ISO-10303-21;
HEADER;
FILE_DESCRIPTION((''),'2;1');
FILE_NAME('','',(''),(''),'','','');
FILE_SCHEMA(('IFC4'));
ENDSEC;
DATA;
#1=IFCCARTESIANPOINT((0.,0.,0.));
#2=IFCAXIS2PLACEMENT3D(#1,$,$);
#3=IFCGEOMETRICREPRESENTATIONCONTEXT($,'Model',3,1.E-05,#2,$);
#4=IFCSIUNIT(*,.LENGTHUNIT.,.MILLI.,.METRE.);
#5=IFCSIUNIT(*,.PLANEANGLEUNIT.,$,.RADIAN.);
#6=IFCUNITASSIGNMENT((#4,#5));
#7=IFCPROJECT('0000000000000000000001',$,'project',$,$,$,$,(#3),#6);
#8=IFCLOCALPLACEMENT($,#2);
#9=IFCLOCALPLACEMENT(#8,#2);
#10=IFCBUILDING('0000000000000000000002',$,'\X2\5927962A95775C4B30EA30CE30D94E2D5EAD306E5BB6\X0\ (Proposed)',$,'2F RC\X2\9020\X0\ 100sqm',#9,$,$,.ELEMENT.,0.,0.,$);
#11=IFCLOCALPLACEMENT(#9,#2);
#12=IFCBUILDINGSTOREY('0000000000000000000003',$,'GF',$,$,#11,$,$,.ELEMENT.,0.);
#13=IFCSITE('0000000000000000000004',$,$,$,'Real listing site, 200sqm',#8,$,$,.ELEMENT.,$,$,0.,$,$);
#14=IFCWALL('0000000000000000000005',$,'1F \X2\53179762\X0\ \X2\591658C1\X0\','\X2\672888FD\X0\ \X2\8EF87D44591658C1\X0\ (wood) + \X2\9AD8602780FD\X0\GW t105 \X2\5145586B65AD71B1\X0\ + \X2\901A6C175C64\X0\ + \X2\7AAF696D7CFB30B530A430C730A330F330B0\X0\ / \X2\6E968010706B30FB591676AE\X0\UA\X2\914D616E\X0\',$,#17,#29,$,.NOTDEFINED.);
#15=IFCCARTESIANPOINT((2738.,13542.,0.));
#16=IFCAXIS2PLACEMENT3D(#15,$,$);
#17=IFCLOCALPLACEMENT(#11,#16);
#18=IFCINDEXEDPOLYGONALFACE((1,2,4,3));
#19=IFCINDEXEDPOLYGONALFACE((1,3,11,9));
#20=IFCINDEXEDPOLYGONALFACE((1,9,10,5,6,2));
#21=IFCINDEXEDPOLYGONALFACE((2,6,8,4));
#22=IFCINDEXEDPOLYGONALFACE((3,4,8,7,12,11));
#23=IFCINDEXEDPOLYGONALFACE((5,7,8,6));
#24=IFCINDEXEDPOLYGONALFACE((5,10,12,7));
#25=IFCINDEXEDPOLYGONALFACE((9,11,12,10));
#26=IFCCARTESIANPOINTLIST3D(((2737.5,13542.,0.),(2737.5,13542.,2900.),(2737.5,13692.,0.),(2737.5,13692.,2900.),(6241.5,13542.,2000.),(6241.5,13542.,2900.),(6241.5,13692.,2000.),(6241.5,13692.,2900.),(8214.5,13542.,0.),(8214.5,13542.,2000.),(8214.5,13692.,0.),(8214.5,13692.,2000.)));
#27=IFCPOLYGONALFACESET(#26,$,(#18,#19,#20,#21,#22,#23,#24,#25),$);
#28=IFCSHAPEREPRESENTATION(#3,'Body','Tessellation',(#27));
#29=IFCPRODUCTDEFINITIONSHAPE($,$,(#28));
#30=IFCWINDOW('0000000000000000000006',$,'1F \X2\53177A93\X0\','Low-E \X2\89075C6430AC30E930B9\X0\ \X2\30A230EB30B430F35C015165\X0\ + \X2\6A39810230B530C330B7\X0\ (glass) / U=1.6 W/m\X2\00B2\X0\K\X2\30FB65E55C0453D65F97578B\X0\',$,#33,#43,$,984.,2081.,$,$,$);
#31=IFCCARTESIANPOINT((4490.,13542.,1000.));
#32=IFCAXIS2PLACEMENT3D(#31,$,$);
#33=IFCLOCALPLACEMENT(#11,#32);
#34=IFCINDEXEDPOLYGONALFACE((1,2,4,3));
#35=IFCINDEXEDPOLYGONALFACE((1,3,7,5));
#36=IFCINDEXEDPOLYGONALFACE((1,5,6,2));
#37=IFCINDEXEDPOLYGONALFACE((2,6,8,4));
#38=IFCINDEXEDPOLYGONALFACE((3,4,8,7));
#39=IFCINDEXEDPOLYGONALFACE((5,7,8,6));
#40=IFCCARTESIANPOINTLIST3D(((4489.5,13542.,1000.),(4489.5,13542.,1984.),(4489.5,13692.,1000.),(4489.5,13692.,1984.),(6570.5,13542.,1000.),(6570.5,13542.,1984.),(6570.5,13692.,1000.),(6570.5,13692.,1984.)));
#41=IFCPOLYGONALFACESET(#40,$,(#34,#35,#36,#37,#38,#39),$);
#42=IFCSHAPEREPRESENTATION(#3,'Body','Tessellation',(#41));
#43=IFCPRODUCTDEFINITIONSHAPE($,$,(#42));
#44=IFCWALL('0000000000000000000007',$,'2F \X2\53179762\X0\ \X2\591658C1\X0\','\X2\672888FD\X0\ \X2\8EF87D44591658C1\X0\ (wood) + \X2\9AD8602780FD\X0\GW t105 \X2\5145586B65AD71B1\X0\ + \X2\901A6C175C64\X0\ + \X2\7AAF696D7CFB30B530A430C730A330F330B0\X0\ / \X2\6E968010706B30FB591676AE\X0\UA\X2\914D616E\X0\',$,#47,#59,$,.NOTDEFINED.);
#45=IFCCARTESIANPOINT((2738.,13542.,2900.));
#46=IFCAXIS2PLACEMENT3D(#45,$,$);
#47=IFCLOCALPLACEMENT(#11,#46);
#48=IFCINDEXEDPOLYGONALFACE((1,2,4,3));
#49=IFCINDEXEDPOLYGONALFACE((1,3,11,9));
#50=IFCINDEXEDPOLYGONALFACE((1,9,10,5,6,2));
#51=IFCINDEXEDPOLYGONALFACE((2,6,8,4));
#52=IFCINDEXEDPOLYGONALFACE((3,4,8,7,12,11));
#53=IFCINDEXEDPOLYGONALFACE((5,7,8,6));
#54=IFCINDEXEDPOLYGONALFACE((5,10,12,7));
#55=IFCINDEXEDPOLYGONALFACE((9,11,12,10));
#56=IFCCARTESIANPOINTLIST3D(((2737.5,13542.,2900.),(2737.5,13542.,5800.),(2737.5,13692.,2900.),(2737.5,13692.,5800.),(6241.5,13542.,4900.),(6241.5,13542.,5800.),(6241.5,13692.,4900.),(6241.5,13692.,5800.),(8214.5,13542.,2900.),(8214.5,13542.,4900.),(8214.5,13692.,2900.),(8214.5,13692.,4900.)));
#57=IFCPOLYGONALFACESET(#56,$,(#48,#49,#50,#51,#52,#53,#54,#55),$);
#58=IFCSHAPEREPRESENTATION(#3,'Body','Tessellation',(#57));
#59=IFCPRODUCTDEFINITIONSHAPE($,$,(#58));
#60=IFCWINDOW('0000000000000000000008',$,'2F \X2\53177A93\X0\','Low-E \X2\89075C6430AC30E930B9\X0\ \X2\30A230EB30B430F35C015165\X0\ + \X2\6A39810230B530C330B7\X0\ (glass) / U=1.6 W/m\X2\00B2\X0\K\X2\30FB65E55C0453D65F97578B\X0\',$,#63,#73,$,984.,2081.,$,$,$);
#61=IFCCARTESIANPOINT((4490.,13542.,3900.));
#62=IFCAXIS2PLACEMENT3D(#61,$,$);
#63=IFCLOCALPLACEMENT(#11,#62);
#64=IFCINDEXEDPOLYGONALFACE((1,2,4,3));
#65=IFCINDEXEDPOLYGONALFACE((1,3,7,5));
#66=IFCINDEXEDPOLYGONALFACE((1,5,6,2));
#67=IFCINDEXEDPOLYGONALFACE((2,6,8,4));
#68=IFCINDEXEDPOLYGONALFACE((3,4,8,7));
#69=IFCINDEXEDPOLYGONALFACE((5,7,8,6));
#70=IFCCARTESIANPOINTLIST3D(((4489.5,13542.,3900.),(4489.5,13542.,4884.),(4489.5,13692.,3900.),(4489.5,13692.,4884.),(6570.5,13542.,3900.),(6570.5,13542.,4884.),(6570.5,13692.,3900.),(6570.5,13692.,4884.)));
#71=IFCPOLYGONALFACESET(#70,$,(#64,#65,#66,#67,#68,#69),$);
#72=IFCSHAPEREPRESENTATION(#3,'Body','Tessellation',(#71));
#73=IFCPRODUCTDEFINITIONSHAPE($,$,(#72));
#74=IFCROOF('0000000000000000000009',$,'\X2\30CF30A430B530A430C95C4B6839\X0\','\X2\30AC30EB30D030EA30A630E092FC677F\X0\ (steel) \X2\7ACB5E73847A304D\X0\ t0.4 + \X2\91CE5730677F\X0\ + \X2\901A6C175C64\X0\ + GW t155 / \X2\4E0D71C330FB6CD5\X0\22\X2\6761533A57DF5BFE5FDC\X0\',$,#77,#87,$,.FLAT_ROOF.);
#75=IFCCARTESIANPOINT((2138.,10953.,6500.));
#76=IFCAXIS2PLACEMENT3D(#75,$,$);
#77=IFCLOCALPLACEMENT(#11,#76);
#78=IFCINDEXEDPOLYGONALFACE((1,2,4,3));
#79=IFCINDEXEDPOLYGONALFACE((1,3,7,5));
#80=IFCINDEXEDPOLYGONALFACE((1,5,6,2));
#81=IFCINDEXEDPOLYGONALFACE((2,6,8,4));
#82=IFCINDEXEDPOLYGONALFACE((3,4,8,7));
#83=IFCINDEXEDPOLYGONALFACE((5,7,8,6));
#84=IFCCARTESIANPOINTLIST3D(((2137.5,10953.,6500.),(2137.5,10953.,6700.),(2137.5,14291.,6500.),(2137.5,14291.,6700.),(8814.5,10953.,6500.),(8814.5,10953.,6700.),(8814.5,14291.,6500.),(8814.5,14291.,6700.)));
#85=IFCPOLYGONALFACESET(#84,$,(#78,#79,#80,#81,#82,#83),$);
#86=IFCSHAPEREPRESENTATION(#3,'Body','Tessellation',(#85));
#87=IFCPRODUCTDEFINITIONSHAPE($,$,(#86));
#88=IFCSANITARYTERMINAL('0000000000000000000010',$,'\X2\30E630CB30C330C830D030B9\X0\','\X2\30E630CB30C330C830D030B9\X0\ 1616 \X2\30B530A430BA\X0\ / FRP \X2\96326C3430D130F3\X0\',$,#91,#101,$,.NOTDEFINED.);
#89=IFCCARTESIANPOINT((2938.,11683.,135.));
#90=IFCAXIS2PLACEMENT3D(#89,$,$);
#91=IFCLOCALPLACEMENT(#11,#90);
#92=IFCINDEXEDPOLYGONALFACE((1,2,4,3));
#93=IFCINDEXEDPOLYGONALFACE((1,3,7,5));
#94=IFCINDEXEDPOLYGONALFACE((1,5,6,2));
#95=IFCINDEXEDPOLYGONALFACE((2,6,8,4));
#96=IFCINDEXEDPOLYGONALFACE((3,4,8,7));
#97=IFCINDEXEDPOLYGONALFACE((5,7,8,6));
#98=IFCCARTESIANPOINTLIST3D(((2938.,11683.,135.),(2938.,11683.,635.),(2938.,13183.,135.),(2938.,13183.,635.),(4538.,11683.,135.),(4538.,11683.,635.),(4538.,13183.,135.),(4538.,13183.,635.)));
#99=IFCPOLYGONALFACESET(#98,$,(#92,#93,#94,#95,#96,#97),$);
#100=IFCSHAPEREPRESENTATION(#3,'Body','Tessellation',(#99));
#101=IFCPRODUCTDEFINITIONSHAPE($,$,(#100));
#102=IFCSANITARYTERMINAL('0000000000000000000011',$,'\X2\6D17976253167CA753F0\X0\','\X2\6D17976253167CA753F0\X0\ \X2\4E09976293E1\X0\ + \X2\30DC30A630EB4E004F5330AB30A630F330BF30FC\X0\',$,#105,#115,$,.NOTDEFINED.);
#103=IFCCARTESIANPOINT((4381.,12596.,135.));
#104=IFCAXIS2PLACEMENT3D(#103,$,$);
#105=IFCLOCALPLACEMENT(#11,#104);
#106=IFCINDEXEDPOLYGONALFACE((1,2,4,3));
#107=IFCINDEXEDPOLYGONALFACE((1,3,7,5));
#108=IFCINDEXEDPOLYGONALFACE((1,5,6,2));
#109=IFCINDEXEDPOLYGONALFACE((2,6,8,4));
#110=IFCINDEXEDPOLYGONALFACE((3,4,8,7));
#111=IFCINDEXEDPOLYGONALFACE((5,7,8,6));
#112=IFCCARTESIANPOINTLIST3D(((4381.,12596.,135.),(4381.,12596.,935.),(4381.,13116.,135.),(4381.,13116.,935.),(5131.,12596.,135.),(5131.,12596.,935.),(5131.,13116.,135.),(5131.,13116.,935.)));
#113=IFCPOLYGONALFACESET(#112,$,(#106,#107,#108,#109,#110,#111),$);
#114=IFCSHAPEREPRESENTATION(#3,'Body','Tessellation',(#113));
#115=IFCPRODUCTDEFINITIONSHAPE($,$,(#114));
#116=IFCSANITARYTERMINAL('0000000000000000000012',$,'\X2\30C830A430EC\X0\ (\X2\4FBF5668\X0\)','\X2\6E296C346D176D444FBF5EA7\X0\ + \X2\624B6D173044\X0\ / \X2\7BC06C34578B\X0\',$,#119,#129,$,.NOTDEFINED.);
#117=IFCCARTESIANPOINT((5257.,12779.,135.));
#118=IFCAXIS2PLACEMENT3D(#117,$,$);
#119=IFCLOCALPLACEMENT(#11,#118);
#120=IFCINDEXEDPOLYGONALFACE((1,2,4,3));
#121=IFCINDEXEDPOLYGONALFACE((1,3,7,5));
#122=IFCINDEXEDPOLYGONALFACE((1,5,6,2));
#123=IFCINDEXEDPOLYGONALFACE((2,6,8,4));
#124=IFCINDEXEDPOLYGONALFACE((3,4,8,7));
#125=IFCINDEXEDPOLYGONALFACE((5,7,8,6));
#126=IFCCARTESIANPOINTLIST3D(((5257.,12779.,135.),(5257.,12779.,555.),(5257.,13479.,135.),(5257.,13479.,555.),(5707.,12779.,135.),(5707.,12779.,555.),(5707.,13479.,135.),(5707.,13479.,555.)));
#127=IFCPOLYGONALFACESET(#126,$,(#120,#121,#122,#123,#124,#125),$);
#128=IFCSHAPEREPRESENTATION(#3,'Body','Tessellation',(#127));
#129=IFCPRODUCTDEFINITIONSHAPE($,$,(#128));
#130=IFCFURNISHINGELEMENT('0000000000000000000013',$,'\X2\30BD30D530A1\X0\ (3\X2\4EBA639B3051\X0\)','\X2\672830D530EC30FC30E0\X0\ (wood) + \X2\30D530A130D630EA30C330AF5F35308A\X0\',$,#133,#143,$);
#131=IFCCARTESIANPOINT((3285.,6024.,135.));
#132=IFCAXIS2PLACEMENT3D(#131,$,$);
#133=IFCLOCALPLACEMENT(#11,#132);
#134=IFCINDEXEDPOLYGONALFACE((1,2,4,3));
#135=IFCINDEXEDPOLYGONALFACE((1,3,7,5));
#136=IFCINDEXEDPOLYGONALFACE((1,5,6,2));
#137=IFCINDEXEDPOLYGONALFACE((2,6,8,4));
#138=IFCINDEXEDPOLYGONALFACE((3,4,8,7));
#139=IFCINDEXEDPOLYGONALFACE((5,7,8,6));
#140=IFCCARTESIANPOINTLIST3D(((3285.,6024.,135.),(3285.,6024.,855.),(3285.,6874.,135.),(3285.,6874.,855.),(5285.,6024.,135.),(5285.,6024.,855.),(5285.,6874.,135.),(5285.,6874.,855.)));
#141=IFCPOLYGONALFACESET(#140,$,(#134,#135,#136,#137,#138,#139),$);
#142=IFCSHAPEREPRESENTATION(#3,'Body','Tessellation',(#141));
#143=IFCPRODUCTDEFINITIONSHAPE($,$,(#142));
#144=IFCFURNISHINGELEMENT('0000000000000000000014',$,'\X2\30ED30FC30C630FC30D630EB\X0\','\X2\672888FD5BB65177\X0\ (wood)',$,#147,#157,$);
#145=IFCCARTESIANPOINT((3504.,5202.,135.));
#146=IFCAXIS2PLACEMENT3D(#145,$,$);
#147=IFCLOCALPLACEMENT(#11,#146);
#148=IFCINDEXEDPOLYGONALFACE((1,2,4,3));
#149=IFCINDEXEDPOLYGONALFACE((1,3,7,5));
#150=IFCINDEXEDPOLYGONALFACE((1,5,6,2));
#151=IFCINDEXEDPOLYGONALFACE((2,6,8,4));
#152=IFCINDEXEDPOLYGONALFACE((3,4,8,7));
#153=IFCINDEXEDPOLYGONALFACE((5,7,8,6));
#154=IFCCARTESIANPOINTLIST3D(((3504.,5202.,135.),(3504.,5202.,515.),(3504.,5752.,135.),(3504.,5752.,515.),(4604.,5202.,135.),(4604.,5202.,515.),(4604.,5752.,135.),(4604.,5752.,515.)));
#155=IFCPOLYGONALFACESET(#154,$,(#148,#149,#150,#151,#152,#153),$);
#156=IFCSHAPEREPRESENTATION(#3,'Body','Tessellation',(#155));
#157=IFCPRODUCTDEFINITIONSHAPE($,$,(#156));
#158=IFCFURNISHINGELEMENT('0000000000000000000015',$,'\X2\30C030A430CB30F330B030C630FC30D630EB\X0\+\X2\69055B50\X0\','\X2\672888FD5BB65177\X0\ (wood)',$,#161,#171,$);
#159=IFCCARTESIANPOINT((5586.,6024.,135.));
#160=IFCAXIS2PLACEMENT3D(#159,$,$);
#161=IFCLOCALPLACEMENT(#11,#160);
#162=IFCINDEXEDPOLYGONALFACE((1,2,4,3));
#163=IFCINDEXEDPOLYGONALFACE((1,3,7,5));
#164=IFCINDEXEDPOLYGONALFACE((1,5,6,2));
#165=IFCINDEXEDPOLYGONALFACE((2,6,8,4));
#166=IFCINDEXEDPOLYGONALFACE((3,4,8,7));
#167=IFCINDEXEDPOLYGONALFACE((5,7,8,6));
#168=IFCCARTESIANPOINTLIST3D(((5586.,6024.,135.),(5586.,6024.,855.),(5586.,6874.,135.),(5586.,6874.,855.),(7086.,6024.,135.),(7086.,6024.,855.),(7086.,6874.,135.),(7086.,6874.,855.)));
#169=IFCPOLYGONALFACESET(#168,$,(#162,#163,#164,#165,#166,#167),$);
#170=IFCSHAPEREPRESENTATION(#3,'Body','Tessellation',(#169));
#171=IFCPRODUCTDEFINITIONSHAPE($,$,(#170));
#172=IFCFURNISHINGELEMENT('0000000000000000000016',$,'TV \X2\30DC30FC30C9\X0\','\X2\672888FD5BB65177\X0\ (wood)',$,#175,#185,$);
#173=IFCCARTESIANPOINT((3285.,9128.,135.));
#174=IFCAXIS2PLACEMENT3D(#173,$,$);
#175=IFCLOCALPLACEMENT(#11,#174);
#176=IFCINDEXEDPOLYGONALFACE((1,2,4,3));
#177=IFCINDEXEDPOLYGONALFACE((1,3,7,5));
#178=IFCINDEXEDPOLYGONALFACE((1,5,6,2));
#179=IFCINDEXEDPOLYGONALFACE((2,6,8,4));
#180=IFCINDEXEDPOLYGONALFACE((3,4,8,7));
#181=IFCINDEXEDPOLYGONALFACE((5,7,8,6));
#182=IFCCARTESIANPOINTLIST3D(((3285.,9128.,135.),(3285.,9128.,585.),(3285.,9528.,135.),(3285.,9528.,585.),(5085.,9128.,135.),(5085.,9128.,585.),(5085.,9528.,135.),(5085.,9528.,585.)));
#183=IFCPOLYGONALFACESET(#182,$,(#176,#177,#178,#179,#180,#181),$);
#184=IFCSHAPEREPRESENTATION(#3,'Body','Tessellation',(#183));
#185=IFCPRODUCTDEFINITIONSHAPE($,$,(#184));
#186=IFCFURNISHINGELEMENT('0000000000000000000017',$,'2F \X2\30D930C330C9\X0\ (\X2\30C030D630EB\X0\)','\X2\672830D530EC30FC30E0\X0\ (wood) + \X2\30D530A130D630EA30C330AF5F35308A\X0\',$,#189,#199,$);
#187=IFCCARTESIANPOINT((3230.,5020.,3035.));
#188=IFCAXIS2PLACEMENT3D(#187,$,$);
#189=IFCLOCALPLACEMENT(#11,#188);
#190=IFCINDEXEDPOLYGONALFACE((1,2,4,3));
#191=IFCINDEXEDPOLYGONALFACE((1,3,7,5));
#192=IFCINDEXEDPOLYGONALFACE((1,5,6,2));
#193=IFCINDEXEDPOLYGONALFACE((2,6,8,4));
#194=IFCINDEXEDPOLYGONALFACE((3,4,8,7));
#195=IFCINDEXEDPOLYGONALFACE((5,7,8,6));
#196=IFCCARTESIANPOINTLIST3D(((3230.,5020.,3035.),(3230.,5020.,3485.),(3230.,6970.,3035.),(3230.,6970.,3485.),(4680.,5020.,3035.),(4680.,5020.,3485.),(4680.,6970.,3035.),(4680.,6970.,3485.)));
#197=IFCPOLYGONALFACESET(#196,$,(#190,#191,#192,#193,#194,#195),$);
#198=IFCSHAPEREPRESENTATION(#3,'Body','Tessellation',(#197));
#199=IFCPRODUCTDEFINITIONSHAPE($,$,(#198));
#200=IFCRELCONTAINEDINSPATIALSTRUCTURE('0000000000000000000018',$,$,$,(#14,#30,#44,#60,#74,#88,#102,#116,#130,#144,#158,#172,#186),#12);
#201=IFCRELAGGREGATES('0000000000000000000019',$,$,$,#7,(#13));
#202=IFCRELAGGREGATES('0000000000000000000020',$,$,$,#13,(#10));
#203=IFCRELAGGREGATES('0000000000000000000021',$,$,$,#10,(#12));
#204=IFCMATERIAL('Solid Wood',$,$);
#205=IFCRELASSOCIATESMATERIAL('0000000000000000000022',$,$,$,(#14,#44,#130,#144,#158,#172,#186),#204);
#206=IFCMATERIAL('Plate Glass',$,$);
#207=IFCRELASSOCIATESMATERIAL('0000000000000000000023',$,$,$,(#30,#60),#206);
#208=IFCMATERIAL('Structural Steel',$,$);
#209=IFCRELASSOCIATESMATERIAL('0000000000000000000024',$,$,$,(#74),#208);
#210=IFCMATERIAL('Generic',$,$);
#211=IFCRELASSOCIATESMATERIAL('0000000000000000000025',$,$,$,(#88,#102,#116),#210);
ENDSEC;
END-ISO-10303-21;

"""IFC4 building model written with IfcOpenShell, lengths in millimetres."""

from ifc_helpers import new_model, si_unit, frame, frame_2d, origin, place, context, project, spatial, rectangle, extrude, material, element, fill, save


model = new_model("IFC4")

# Units and contexts
model_context = context("Model", 3, precision=1e-05, world=origin())
ifc_project = project(units=[si_unit("LENGTHUNIT", "METRE", prefix="MILLI"), si_unit("PLANEANGLEUNIT", "RADIAN")], contexts=[model_context])

# Site, building, storey
site_placement = place(None, origin())
site = spatial("IfcSite", under=ifc_project, at=site_placement, ObjectType="Real listing site, 200sqm", CompositionType="ELEMENT", RefElevation=0.0)
building_placement = place(site_placement, origin())
building = spatial("IfcBuilding", under=site, at=building_placement, Name="大阪長屋リノベ中庭の家 (Proposed)", ObjectType="2F RC造 100sqm", CompositionType="ELEMENT", ElevationOfRefHeight=0.0, ElevationOfTerrain=0.0)
storey_placement = place(building_placement, origin())
storey = spatial("IfcBuildingStorey", under=building, at=storey_placement, Name="GF", CompositionType="ELEMENT", Elevation=0.0)

# Wall, opening, window
ifc_material_1 = material(Name="Solid Wood")
wall_1_placement = place(storey_placement, frame((2738.0, 13542.0, 0.0)))
wall_1 = element("IfcWall", 1, at=wall_1_placement, inside=storey, material=ifc_material_1, Name="1F 北面 外壁", Description="木製 軸組外壁 (wood) + 高性能GW t105 充填断熱 + 通気層 + 窯業系サイディング / 準耐火・外皮UA配慮", PredefinedType="NOTDEFINED", context=model_context, shape_type="SweptSolid", body=[
    extrude(rectangle(XDim=5477.0, YDim=150.0, at=frame_2d((2738.0, 75.0))), frame((2738.0, 13542.0, 0.0)), (0.0, 0.0, 1.0), 2900.0),
])
opening_1_placement = place(storey_placement, frame((4490.0, 13542.0, 1000.0)))
opening_1 = element("IfcOpeningElement", 2, at=opening_1_placement, cuts=wall_1, PredefinedType="NOTDEFINED", context=model_context, shape_type="SweptSolid", body=[
    extrude(rectangle(XDim=2081.0, YDim=150.0, at=frame_2d((1040.0, 75.0))), frame((4490.0, 13542.0, 1000.0)), (0.0, 0.0, 1.0), 984.0),
])
ifc_material_2 = material(Name="Plate Glass")
window_1_placement = place(storey_placement, frame((4490.0, 13542.0, 1000.0)))
window_1 = element("IfcWindow", 3, at=window_1_placement, inside=storey, material=ifc_material_2, Name="1F 北窓", Description="Low-E 複層ガラス アルゴン封入 + 樹脂サッシ (glass) / U=1.6 W/m²K・日射取得型", OverallHeight=984.0, OverallWidth=2081.0, context=model_context, shape_type="SweptSolid", body=[
    extrude(rectangle(XDim=2081.0, YDim=150.0, at=frame_2d((1040.0, 75.0))), frame((4490.0, 13542.0, 1000.0)), (0.0, 0.0, 1.0), 984.0),
])
fill(opening_1, window_1)

# Wall, opening, window
wall_2_placement = place(storey_placement, frame((2738.0, 13542.0, 2900.0)))
wall_2 = element("IfcWall", 4, at=wall_2_placement, inside=storey, material=ifc_material_1, Name="2F 北面 外壁", Description="木製 軸組外壁 (wood) + 高性能GW t105 充填断熱 + 通気層 + 窯業系サイディング / 準耐火・外皮UA配慮", PredefinedType="NOTDEFINED", context=model_context, shape_type="SweptSolid", body=[
    extrude(rectangle(XDim=5477.0, YDim=150.0, at=frame_2d((2738.0, 75.0))), frame((2738.0, 13542.0, 2900.0)), (0.0, 0.0, 1.0), 2900.0),
])
opening_2_placement = place(storey_placement, frame((4490.0, 13542.0, 3900.0)))
opening_2 = element("IfcOpeningElement", 5, at=opening_2_placement, cuts=wall_2, PredefinedType="NOTDEFINED", context=model_context, shape_type="SweptSolid", body=[
    extrude(rectangle(XDim=2081.0, YDim=150.0, at=frame_2d((1040.0, 75.0))), frame((4490.0, 13542.0, 3900.0)), (0.0, 0.0, 1.0), 984.0),
])
window_2_placement = place(storey_placement, frame((4490.0, 13542.0, 3900.0)))
window_2 = element("IfcWindow", 6, at=window_2_placement, inside=storey, material=ifc_material_2, Name="2F 北窓", Description="Low-E 複層ガラス アルゴン封入 + 樹脂サッシ (glass) / U=1.6 W/m²K・日射取得型", OverallHeight=984.0, OverallWidth=2081.0, context=model_context, shape_type="SweptSolid", body=[
    extrude(rectangle(XDim=2081.0, YDim=150.0, at=frame_2d((1040.0, 75.0))), frame((4490.0, 13542.0, 3900.0)), (0.0, 0.0, 1.0), 984.0),
])
fill(opening_2, window_2)

# Roof
ifc_material_3 = material(Name="Structural Steel")
roof_placement = place(storey_placement, frame((2138.0, 10953.0, 6500.0)))
element("IfcRoof", 7, at=roof_placement, inside=storey, material=ifc_material_3, Name="ハイサイド屋根", Description="ガルバリウム鋼板 (steel) 立平葺き t0.4 + 野地板 + 通気層 + GW t155 / 不燃・法22条区域対応", PredefinedType="FLAT_ROOF", context=model_context, shape_type="SweptSolid", body=[
    extrude(rectangle(XDim=6677.0, YDim=3338.0, at=frame_2d((3338.0, 1669.0))), frame((2138.0, 10953.0, 6500.0)), (0.0, 0.0, 1.0), 200.0),
])

# Sanitary terminals
ifc_material_4 = material(Name="Generic")
sanitary_terminal_1_placement = place(storey_placement, frame((2938.0, 11683.0, 135.0)))
element("IfcSanitaryTerminal", 8, at=sanitary_terminal_1_placement, inside=storey, material=ifc_material_4, Name="ユニットバス", Description="ユニットバス 1616 サイズ / FRP 防水パン", PredefinedType="NOTDEFINED", context=model_context, shape_type="SweptSolid", body=[
    extrude(rectangle(XDim=1600.0, YDim=1500.0, at=frame_2d((800.0, 750.0))), frame((2938.0, 11683.0, 135.0)), (0.0, 0.0, 1.0), 500.0),
])
sanitary_terminal_2_placement = place(storey_placement, frame((4381.0, 12596.0, 135.0)))
element("IfcSanitaryTerminal", 9, at=sanitary_terminal_2_placement, inside=storey, material=ifc_material_4, Name="洗面化粧台", Description="洗面化粧台 三面鏡 + ボウル一体カウンター", PredefinedType="NOTDEFINED", context=model_context, shape_type="SweptSolid", body=[
    extrude(rectangle(XDim=750.0, YDim=520.0, at=frame_2d((375.0, 260.0))), frame((4381.0, 12596.0, 135.0)), (0.0, 0.0, 1.0), 800.0),
])
sanitary_terminal_3_placement = place(storey_placement, frame((5257.0, 12779.0, 135.0)))
element("IfcSanitaryTerminal", 10, at=sanitary_terminal_3_placement, inside=storey, material=ifc_material_4, Name="トイレ (便器)", Description="温水洗浄便座 + 手洗い / 節水型", PredefinedType="NOTDEFINED", context=model_context, shape_type="SweptSolid", body=[
    extrude(rectangle(XDim=450.0, YDim=700.0, at=frame_2d((225.0, 350.0))), frame((5257.0, 12779.0, 135.0)), (0.0, 0.0, 1.0), 420.0),
])

# Furnishing elements
furnishing_1_placement = place(storey_placement, frame((3285.0, 6024.0, 135.0)))
element("IfcFurnishingElement", 11, at=furnishing_1_placement, inside=storey, material=ifc_material_1, Name="ソファ (3人掛け)", Description="木フレーム (wood) + ファブリック張り", context=model_context, shape_type="SweptSolid", body=[
    extrude(rectangle(XDim=2000.0, YDim=850.0, at=frame_2d((1000.0, 425.0))), frame((3285.0, 6024.0, 135.0)), (0.0, 0.0, 1.0), 720.0),
])
furnishing_2_placement = place(storey_placement, frame((3504.0, 5202.0, 135.0)))
element("IfcFurnishingElement", 12, at=furnishing_2_placement, inside=storey, material=ifc_material_1, Name="ローテーブル", Description="木製家具 (wood)", context=model_context, shape_type="SweptSolid", body=[
    extrude(rectangle(XDim=1100.0, YDim=550.0, at=frame_2d((550.0, 275.0))), frame((3504.0, 5202.0, 135.0)), (0.0, 0.0, 1.0), 380.0),
])
furnishing_3_placement = place(storey_placement, frame((5586.0, 6024.0, 135.0)))
element("IfcFurnishingElement", 13, at=furnishing_3_placement, inside=storey, material=ifc_material_1, Name="ダイニングテーブル+椅子", Description="木製家具 (wood)", context=model_context, shape_type="SweptSolid", body=[
    extrude(rectangle(XDim=1500.0, YDim=850.0, at=frame_2d((750.0, 425.0))), frame((5586.0, 6024.0, 135.0)), (0.0, 0.0, 1.0), 720.0),
])
furnishing_4_placement = place(storey_placement, frame((3285.0, 9128.0, 135.0)))
element("IfcFurnishingElement", 14, at=furnishing_4_placement, inside=storey, material=ifc_material_1, Name="TV ボード", Description="木製家具 (wood)", context=model_context, shape_type="SweptSolid", body=[
    extrude(rectangle(XDim=1800.0, YDim=400.0, at=frame_2d((900.0, 200.0))), frame((3285.0, 9128.0, 135.0)), (0.0, 0.0, 1.0), 450.0),
])
furnishing_5_placement = place(storey_placement, frame((3230.0, 5020.0, 3035.0)))
element("IfcFurnishingElement", 15, at=furnishing_5_placement, inside=storey, material=ifc_material_1, Name="2F ベッド (ダブル)", Description="木フレーム (wood) + ファブリック張り", context=model_context, shape_type="SweptSolid", body=[
    extrude(rectangle(XDim=1450.0, YDim=1950.0, at=frame_2d((725.0, 975.0))), frame((3230.0, 5020.0, 3035.0)), (0.0, 0.0, 1.0), 450.0),
])

save(model, "model.ifc")
